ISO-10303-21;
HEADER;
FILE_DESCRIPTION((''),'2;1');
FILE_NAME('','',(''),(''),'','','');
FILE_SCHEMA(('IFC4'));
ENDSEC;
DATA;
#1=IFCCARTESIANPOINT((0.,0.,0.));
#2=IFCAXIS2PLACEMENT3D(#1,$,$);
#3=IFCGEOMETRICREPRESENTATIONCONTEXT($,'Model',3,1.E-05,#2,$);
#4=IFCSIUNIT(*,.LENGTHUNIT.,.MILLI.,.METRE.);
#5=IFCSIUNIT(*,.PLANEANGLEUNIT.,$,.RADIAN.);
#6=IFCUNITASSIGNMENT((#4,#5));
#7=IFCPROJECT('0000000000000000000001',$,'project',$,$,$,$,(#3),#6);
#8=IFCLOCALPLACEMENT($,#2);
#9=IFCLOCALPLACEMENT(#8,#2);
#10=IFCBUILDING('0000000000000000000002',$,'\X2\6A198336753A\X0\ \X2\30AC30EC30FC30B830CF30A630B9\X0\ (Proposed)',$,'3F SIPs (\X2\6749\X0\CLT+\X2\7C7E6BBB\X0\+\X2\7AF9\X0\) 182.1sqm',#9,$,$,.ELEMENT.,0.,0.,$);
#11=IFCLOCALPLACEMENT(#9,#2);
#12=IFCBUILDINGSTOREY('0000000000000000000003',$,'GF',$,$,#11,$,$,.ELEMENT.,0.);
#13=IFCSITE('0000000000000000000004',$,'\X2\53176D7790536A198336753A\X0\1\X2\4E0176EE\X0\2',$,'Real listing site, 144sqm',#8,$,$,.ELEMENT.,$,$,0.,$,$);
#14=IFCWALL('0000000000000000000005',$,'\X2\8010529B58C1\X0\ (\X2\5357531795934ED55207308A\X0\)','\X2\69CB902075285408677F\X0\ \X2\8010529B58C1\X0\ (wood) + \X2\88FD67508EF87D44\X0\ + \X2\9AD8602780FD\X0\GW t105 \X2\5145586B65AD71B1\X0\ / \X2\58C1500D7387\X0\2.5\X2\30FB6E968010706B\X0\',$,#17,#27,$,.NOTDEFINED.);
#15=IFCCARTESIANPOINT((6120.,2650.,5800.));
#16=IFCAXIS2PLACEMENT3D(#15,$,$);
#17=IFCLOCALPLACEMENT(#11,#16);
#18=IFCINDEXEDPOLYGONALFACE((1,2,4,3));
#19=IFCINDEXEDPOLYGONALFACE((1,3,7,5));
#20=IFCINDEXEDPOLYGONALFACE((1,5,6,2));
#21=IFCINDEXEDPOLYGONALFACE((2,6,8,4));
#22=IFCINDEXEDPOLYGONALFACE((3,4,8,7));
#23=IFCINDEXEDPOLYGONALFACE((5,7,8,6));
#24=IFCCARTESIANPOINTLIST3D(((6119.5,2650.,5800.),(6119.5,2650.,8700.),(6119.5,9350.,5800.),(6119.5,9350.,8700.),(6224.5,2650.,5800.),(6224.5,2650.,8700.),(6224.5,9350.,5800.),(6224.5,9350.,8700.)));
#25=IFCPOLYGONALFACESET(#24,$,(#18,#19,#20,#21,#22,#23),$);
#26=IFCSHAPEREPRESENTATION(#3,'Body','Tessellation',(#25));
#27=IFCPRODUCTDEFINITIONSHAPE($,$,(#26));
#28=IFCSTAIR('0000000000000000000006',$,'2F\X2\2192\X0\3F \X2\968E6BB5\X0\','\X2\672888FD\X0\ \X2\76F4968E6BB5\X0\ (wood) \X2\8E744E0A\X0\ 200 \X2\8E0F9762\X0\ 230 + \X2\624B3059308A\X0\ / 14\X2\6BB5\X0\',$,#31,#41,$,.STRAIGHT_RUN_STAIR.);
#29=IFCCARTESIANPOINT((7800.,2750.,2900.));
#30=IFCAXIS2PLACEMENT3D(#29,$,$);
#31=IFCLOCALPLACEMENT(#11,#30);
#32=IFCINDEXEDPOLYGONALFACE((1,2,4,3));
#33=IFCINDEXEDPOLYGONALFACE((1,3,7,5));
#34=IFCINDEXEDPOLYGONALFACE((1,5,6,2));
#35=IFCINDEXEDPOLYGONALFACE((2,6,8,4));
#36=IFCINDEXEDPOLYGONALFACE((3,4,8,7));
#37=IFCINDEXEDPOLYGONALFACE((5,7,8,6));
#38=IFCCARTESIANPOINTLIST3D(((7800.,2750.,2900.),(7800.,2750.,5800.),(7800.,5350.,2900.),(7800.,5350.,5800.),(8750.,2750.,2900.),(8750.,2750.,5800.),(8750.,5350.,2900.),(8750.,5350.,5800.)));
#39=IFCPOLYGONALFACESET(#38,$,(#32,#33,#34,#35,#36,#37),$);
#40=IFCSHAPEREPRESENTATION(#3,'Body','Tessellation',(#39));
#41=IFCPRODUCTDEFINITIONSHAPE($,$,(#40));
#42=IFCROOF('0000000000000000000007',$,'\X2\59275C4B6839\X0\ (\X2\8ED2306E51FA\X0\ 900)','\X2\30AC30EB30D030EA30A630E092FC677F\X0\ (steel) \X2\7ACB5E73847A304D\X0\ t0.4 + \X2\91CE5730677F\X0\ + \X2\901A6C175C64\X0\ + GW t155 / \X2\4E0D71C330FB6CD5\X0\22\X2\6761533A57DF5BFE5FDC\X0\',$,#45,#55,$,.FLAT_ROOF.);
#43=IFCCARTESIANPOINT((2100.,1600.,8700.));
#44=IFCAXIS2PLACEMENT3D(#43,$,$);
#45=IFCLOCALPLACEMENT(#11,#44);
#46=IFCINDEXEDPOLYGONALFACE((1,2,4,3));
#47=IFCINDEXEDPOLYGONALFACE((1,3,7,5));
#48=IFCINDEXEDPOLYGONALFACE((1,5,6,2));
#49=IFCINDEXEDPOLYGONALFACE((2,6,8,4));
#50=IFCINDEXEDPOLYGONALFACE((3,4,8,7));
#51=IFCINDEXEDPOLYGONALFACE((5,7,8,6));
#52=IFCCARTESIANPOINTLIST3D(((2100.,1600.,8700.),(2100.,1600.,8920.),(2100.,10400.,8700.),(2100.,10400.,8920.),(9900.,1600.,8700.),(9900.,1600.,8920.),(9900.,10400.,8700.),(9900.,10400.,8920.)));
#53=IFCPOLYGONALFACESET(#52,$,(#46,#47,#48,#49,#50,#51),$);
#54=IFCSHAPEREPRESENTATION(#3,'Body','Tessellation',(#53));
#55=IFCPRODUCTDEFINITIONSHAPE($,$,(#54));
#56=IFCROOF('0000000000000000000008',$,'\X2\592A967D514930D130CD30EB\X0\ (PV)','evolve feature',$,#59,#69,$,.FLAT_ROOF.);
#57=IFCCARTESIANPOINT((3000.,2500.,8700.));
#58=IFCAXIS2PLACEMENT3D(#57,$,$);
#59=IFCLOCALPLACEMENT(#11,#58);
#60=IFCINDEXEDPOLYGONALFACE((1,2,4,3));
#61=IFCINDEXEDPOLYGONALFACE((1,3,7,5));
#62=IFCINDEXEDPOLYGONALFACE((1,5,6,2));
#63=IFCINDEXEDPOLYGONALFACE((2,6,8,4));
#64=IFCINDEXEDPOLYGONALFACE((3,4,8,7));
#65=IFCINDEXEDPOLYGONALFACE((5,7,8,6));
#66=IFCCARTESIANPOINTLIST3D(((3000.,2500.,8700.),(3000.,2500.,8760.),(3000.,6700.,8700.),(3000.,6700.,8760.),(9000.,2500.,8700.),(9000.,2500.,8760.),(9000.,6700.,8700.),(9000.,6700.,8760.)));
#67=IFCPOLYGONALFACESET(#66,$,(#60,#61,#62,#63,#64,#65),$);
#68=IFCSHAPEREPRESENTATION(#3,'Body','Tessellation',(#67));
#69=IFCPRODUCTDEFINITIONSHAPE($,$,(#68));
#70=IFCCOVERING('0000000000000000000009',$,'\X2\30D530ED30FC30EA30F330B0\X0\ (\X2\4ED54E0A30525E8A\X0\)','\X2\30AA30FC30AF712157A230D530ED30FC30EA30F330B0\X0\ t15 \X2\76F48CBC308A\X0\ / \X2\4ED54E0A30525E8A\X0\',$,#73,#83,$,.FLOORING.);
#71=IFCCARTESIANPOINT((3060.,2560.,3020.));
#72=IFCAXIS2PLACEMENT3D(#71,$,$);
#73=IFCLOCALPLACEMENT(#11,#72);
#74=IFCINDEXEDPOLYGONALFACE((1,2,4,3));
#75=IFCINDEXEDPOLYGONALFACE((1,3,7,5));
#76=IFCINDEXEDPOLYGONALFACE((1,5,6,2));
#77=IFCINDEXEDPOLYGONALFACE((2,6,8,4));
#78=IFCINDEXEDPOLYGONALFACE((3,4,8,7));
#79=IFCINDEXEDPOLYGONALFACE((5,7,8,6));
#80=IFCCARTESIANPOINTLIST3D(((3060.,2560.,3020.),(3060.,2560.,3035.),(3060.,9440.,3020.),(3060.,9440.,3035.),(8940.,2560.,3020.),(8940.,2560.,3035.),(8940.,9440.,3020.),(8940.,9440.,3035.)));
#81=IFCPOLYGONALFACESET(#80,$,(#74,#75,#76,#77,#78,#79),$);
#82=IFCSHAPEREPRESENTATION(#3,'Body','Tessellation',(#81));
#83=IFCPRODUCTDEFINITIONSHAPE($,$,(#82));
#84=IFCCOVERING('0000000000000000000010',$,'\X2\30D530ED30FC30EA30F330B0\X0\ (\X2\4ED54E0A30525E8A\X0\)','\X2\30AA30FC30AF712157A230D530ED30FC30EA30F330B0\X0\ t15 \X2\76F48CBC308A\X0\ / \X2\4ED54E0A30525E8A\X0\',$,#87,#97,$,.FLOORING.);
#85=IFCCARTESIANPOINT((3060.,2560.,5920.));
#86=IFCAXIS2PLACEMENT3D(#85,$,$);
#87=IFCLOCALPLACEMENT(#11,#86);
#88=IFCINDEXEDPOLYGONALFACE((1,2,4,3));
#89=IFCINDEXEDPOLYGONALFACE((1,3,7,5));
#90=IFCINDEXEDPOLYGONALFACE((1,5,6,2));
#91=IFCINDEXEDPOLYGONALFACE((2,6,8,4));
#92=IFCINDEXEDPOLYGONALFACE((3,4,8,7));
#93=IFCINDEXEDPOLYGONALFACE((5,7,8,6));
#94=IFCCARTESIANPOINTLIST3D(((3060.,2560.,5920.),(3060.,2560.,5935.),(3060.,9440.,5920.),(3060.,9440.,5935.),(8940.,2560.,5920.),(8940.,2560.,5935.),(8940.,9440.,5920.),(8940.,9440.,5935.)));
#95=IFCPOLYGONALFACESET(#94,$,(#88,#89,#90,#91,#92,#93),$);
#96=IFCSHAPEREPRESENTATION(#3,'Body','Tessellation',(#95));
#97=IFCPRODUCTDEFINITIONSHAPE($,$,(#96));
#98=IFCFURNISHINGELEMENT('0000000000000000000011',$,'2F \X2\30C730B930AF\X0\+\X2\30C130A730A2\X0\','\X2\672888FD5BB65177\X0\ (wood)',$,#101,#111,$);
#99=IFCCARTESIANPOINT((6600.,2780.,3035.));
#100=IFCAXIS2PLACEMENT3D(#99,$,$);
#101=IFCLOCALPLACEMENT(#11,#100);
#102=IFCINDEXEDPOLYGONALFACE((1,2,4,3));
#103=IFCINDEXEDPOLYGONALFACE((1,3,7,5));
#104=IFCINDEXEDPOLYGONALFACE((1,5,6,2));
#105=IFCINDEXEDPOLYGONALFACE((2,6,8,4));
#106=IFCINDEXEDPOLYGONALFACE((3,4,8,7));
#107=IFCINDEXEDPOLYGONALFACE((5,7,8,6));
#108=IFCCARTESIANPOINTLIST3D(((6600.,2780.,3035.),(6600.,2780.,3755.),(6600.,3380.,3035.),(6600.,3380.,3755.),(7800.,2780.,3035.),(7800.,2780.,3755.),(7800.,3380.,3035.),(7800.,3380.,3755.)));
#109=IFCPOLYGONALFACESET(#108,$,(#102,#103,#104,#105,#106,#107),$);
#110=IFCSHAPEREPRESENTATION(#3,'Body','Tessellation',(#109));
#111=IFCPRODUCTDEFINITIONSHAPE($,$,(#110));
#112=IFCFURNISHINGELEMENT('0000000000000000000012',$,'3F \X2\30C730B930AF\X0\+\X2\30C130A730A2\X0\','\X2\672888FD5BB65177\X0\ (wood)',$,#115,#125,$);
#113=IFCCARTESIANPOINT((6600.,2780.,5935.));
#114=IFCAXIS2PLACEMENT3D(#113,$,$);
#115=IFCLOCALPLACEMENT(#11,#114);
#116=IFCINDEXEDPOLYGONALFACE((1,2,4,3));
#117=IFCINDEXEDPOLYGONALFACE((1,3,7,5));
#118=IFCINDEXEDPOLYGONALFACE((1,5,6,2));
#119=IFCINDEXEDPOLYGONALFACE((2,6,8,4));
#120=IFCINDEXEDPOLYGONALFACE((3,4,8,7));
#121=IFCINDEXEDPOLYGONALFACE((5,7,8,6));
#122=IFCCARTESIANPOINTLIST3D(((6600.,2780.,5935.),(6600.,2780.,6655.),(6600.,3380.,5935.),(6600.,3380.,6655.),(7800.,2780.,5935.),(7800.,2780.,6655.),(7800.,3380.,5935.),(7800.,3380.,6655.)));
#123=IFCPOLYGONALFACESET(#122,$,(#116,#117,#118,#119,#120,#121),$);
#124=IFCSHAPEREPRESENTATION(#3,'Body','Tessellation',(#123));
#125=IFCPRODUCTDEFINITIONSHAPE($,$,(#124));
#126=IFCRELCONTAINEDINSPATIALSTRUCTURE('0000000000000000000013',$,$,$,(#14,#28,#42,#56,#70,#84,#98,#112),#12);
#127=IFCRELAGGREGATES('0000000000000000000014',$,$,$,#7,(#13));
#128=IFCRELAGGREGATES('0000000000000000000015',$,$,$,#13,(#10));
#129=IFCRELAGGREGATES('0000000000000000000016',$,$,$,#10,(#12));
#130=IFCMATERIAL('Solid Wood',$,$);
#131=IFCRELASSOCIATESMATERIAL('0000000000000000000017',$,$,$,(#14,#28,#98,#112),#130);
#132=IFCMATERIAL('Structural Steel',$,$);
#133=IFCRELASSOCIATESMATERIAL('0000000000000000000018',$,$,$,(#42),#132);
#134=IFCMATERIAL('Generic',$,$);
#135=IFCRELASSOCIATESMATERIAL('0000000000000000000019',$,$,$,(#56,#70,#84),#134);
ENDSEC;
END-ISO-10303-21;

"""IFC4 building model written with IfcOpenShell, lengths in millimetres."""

from ifc_helpers import new_model, si_unit, frame, frame_2d, origin, place, context, project, spatial, rectangle, extrude, material, element, save


model = new_model("IFC4")

# Units and contexts
model_context = context("Model", 3, precision=1e-05, world=origin())
ifc_project = project(units=[si_unit("LENGTHUNIT", "METRE", prefix="MILLI"), si_unit("PLANEANGLEUNIT", "RADIAN")], contexts=[model_context])

# Site, building, storey
site_placement = place(None, origin())
site = spatial("IfcSite", under=ifc_project, at=site_placement, Name="北海道標茶町1丁目2", ObjectType="Real listing site, 144sqm", CompositionType="ELEMENT", RefElevation=0.0)
building_placement = place(site_placement, origin())
building = spatial("IfcBuilding", under=site, at=building_placement, Name="標茶町 ガレージハウス (Proposed)", ObjectType="3F SIPs (杉CLT+籾殻+竹) 182.1sqm", CompositionType="ELEMENT", ElevationOfRefHeight=0.0, ElevationOfTerrain=0.0)
storey_placement = place(building_placement, origin())
storey = spatial("IfcBuildingStorey", under=building, at=storey_placement, Name="GF", CompositionType="ELEMENT", Elevation=0.0)

# Shared definitions
ifc_material_1 = material(Name="Solid Wood")

# Wall
wall_1_placement = place(storey_placement, frame((6120.0, 2650.0, 5800.0)))
element("IfcWall", 1, at=wall_1_placement, inside=storey, material=ifc_material_1, Name="耐力壁 (南北間仕切り)", Description="構造用合板 耐力壁 (wood) + 製材軸組 + 高性能GW t105 充填断熱 / 壁倍率2.5・準耐火", PredefinedType="NOTDEFINED", context=model_context, shape_type="SweptSolid", body=[
    extrude(rectangle(XDim=105.0, YDim=6700.0, at=frame_2d((52.0, 3350.0))), frame((6120.0, 2650.0, 5800.0)), (0.0, 0.0, 1.0), 2900.0),
])

# Stair
stair_placement = place(storey_placement, frame((7800.0, 2750.0, 2900.0)))
element("IfcStair", 2, at=stair_placement, inside=storey, material=ifc_material_1, Name="2F→3F 階段", Description="木製 直階段 (wood) 蹴上 200 踏面 230 + 手すり / 14段", PredefinedType="STRAIGHT_RUN_STAIR", context=model_context, shape_type="SweptSolid", body=[
    extrude(rectangle(XDim=950.0, YDim=2600.0, at=frame_2d((475.0, 1300.0))), frame((7800.0, 2750.0, 2900.0)), (0.0, 0.0, 1.0), 2900.0),
])

# Roofs
ifc_material_2 = material(Name="Structural Steel")
roof_1_placement = place(storey_placement, frame((2100.0, 1600.0, 8700.0)))
element("IfcRoof", 3, at=roof_1_placement, inside=storey, material=ifc_material_2, Name="大屋根 (軒の出 900)", Description="ガルバリウム鋼板 (steel) 立平葺き t0.4 + 野地板 + 通気層 + GW t155 / 不燃・法22条区域対応", PredefinedType="FLAT_ROOF", context=model_context, shape_type="SweptSolid", body=[
    extrude(rectangle(XDim=7800.0, YDim=8800.0, at=frame_2d((3900.0, 4400.0))), frame((2100.0, 1600.0, 8700.0)), (0.0, 0.0, 1.0), 220.0),
])
ifc_material_3 = material(Name="Generic")
roof_2_placement = place(storey_placement, frame((3000.0, 2500.0, 8700.0)))
element("IfcRoof", 4, at=roof_2_placement, inside=storey, material=ifc_material_3, Name="太陽光パネル (PV)", Description="evolve feature", PredefinedType="FLAT_ROOF", context=model_context, shape_type="SweptSolid", body=[
    extrude(rectangle(XDim=6000.0, YDim=4200.0, at=frame_2d((3000.0, 2100.0))), frame((3000.0, 2500.0, 8700.0)), (0.0, 0.0, 1.0), 60.0),
])

# Coverings
covering_1_placement = place(storey_placement, frame((3060.0, 2560.0, 3020.0)))
element("IfcCovering", 5, at=covering_1_placement, inside=storey, material=ifc_material_3, Name="フローリング (仕上げ床)", Description="オーク無垢フローリング t15 直貼り / 仕上げ床", PredefinedType="FLOORING", context=model_context, shape_type="SweptSolid", body=[
    extrude(rectangle(XDim=5880.0, YDim=6880.0, at=frame_2d((2940.0, 3440.0))), frame((3060.0, 2560.0, 3020.0)), (0.0, 0.0, 1.0), 15.0),
])
covering_2_placement = place(storey_placement, frame((3060.0, 2560.0, 5920.0)))
element("IfcCovering", 6, at=covering_2_placement, inside=storey, material=ifc_material_3, Name="フローリング (仕上げ床)", Description="オーク無垢フローリング t15 直貼り / 仕上げ床", PredefinedType="FLOORING", context=model_context, shape_type="SweptSolid", body=[
    extrude(rectangle(XDim=5880.0, YDim=6880.0, at=frame_2d((2940.0, 3440.0))), frame((3060.0, 2560.0, 5920.0)), (0.0, 0.0, 1.0), 15.0),
])

# Furnishing elements
furnishing_1_placement = place(storey_placement, frame((6600.0, 2780.0, 3035.0)))
element("IfcFurnishingElement", 7, at=furnishing_1_placement, inside=storey, material=ifc_material_1, Name="2F デスク+チェア", Description="木製家具 (wood)", context=model_context, shape_type="SweptSolid", body=[
    extrude(rectangle(XDim=1200.0, YDim=600.0, at=frame_2d((600.0, 300.0))), frame((6600.0, 2780.0, 3035.0)), (0.0, 0.0, 1.0), 720.0),
])
furnishing_2_placement = place(storey_placement, frame((6600.0, 2780.0, 5935.0)))
element("IfcFurnishingElement", 8, at=furnishing_2_placement, inside=storey, material=ifc_material_1, Name="3F デスク+チェア", Description="木製家具 (wood)", context=model_context, shape_type="SweptSolid", body=[
    extrude(rectangle(XDim=1200.0, YDim=600.0, at=frame_2d((600.0, 300.0))), frame((6600.0, 2780.0, 5935.0)), (0.0, 0.0, 1.0), 720.0),
])

save(model, "model.ifc")
